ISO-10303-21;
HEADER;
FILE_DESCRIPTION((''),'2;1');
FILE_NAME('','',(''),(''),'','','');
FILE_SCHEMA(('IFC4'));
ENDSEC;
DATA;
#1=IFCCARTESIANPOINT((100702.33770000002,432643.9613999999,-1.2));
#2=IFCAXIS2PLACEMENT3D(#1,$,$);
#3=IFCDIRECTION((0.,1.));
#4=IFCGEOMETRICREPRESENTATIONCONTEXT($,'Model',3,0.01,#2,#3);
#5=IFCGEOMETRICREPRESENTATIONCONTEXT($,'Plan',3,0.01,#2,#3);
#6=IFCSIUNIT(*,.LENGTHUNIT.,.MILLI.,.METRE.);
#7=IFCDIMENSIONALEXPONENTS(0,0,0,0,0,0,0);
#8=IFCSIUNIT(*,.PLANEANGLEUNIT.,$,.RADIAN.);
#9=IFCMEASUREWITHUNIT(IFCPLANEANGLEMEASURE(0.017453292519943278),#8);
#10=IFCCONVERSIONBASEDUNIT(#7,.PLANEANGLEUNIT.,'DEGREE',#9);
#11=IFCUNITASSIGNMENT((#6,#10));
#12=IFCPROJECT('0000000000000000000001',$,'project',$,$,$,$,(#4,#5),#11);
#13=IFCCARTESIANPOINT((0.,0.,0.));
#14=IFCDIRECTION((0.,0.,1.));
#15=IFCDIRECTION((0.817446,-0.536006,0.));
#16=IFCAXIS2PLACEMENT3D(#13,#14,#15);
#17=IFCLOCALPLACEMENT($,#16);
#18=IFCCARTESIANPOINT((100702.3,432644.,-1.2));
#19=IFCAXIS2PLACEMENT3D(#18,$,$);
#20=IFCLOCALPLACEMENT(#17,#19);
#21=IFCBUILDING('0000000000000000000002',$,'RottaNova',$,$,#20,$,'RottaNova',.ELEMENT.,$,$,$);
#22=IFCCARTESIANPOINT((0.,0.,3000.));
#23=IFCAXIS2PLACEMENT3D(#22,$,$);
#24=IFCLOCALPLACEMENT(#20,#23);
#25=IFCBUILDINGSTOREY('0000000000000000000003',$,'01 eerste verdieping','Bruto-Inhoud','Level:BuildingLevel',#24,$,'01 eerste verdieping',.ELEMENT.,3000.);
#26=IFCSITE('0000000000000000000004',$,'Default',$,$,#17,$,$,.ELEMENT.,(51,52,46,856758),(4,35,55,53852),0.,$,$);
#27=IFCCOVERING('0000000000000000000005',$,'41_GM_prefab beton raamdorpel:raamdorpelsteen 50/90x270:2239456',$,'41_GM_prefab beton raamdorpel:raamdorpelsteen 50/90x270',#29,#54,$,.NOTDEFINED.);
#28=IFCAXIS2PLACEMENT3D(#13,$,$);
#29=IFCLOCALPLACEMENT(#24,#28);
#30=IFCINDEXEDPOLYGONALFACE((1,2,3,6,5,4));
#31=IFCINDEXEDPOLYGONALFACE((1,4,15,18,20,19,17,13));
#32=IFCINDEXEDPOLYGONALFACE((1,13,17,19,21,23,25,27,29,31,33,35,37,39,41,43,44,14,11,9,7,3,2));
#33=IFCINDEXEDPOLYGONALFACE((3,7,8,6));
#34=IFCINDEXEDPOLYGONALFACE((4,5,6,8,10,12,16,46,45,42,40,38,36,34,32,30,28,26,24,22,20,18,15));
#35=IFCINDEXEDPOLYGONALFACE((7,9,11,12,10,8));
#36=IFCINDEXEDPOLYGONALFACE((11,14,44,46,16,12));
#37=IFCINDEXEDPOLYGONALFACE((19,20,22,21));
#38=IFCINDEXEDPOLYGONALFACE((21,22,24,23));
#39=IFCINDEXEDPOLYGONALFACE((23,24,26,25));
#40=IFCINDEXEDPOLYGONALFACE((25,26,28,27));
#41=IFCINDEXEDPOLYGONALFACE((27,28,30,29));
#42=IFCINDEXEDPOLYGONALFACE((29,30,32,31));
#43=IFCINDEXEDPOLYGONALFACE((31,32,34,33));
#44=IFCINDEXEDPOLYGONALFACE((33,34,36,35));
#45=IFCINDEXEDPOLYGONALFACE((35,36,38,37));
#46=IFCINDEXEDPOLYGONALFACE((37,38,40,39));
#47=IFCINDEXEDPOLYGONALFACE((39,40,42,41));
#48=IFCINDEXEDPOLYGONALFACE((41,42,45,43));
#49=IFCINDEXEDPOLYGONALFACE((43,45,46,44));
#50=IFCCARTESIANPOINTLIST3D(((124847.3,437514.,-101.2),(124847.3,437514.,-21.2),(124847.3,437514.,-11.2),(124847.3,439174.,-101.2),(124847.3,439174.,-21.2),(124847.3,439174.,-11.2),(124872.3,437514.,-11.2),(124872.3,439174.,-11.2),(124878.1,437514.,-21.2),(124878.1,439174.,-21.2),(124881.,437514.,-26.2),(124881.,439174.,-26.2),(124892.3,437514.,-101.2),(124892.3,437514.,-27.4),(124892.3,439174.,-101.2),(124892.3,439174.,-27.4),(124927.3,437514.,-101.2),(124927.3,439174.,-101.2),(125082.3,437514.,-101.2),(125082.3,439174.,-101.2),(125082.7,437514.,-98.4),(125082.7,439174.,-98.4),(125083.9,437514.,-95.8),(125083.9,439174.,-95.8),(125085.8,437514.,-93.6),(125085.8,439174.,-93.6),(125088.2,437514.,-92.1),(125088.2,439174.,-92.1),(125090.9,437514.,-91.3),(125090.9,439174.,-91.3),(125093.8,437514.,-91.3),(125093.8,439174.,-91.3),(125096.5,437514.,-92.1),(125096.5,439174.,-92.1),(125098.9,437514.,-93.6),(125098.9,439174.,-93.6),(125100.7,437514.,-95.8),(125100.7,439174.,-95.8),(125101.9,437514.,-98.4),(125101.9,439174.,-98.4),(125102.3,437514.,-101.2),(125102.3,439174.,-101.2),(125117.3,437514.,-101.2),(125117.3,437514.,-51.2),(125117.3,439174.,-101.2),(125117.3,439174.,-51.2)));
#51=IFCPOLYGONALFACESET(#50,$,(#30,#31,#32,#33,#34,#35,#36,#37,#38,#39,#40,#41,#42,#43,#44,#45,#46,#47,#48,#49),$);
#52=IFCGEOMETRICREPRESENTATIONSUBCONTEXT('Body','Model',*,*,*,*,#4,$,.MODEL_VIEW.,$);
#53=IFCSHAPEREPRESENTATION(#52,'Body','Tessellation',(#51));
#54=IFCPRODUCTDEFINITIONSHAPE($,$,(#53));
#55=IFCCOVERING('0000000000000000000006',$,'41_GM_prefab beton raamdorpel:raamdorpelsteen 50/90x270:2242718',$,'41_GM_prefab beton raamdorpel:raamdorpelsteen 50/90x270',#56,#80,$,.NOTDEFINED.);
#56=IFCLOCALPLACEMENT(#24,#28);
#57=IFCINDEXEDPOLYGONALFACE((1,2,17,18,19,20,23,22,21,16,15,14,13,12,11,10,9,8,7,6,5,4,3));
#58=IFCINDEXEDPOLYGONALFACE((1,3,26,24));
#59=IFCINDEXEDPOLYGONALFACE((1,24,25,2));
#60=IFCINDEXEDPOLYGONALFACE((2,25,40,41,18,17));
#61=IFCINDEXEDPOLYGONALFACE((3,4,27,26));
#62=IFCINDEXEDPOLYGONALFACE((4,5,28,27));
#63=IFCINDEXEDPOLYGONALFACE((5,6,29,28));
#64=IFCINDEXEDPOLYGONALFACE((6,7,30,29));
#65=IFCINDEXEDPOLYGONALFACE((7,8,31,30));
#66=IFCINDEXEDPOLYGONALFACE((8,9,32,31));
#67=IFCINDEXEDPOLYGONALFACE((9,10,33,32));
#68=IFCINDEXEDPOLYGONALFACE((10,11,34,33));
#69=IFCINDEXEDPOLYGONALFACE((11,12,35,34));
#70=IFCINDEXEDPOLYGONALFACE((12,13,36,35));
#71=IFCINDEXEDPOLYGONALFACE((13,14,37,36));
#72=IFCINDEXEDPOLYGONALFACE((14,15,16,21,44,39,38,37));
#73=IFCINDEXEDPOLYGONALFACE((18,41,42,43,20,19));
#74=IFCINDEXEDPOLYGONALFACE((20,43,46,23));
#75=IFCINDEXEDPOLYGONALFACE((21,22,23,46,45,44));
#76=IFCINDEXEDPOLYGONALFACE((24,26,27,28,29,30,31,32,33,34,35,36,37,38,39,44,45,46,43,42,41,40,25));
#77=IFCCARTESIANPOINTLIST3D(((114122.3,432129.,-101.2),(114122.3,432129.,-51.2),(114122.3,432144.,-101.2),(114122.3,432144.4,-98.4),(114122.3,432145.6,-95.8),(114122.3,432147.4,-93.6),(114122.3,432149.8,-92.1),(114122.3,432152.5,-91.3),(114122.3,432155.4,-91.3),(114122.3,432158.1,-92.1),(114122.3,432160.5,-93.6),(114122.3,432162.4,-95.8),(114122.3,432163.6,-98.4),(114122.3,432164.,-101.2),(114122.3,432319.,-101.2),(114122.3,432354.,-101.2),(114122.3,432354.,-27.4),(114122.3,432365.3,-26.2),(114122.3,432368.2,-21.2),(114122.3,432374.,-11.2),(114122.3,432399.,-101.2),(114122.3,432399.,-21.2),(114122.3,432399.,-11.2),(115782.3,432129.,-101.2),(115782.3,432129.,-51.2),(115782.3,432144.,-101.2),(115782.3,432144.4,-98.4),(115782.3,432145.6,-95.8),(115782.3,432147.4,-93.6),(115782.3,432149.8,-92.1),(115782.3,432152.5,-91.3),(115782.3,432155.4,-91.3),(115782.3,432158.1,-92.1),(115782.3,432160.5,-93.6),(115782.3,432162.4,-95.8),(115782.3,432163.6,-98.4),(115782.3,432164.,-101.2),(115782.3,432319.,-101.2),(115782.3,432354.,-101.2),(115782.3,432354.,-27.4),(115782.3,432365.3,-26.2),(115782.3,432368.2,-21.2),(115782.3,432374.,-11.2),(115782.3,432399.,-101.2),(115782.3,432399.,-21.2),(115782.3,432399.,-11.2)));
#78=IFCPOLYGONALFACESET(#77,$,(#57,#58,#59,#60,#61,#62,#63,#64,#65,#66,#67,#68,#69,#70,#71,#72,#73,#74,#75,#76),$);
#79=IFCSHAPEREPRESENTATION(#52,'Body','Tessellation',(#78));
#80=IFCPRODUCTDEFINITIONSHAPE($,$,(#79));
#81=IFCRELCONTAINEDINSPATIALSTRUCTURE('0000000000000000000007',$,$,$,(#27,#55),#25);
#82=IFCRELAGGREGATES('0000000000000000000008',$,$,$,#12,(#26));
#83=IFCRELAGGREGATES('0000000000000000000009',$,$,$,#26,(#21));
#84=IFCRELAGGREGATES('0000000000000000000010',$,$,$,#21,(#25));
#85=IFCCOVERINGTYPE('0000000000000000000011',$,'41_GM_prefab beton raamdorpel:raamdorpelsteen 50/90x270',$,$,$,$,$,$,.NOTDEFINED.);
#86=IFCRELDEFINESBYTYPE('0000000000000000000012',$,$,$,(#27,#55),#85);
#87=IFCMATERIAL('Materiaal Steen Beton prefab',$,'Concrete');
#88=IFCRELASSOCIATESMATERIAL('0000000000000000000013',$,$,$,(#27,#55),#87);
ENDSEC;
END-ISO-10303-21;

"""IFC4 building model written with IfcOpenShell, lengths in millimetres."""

from ifc_helpers import new_model, entity, si_unit, converted_unit, direction, frame, place, context, subcontext, project, spatial, line, arc, indexed_curve, outline, extrude, material, type_object, element, save


model = new_model("IFC4")

# Units and contexts
model_context = context("Model", 3, precision=0.01, world=frame((100702.33770000002, 432643.9613999999, -1.2)), true_north=direction((0.0, 1.0)))
plan_context = context("Plan", 3, precision=0.01, world=frame((100702.33770000002, 432643.9613999999, -1.2)), true_north=direction((0.0, 1.0)))
body_context = subcontext(model_context, "Body", "Model", "MODEL_VIEW")
ifc_project = project(units=[si_unit("LENGTHUNIT", "METRE", prefix="MILLI"), converted_unit("PLANEANGLEUNIT", "DEGREE", entity("IfcPlaneAngleMeasure", 0.017453292519943278), si_unit("PLANEANGLEUNIT", "RADIAN"), dimensions=[0, 0, 0, 0, 0, 0, 0])], contexts=[model_context, plan_context])

# Site, building, storey
site_placement = place(None, frame((0.0, 0.0, 0.0), z_axis=(0.0, 0.0, 1.0), x_axis=(0.817446, -0.536006, 0.0)))
site = spatial("IfcSite", under=ifc_project, at=site_placement, Name="Default", CompositionType="ELEMENT", RefLatitude=(51, 52, 46, 856758), RefLongitude=(4, 35, 55, 53852), RefElevation=0.0)
building_placement = place(site_placement, frame((100702.3, 432644.0, -1.2)))
building = spatial("IfcBuilding", under=site, at=building_placement, Name="RottaNova", LongName="RottaNova", CompositionType="ELEMENT")
storey_placement = place(building_placement, frame((0.0, 0.0, 3000.0)))
storey = spatial("IfcBuildingStorey", under=building, at=storey_placement, Name="01 eerste verdieping", Description="Bruto-Inhoud", ObjectType="Level:BuildingLevel", LongName="01 eerste verdieping", CompositionType="ELEMENT", Elevation=3000.0)

# Shared definitions
ifc_material_1 = material(Name="Materiaal Steen Beton prefab", Category="Concrete")

# Coverings
covering_type = type_object("IfcCoveringType", Name="41_GM_prefab beton raamdorpel:raamdorpelsteen 50/90x270", PredefinedType="NOTDEFINED")
covering_1_placement = place(storey_placement, frame((100702.3, 432644.0, -1.2)))
element("IfcCovering", 1, at=covering_1_placement, inside=storey, type_object=covering_type, material=ifc_material_1, Name="41_GM_prefab beton raamdorpel:raamdorpelsteen 50/90x270:2239456", ObjectType="41_GM_prefab beton raamdorpel:raamdorpelsteen 50/90x270", PredefinedType="NOTDEFINED", context=body_context, shape_type="SweptSolid", body=[
    extrude(outline(indexed_curve([(-79.1, -40.0), (-91.6, -61.6), (-83.0, -66.6), (-13.7, -106.6), (8.8, -67.6), (26.3, -37.3), (103.8, 96.9), (100.1, 110.6), (113.8, 114.2), (121.3, 127.2), (78.0, 152.2), (-55.1, -30.7), (-61.8, -40.0), (-67.6, -40.0)], segments=[line(1, 2, 3, 4, 5, 6, 7), arc(7, 8, 9), line(9, 10, 11, 12, 13, 14, 1)], self_intersect=False)), frame((24244.2, 4870.0, -58.6), z_axis=(0.0, -1.0, 0.0), x_axis=(0.5, 0.0, -0.866025)), (0.0, 0.0, -1.0), 1660.0),
])
covering_2_placement = place(storey_placement, frame((100702.3, 432644.0, -1.2)))
element("IfcCovering", 2, at=covering_2_placement, inside=storey, type_object=covering_type, material=ifc_material_1, Name="41_GM_prefab beton raamdorpel:raamdorpelsteen 50/90x270:2242718", ObjectType="41_GM_prefab beton raamdorpel:raamdorpelsteen 50/90x270", PredefinedType="NOTDEFINED", context=body_context, shape_type="SweptSolid", body=[
    extrude(outline(indexed_curve([(-79.1, -40.0), (-91.6, -61.6), (-83.0, -66.6), (-13.7, -106.6), (8.8, -67.6), (26.3, -37.3), (103.8, 96.9), (100.1, 110.6), (113.8, 114.2), (121.3, 127.2), (78.0, 152.2), (-55.1, -30.7), (-61.8, -40.0), (-67.6, -40.0)], segments=[line(1, 2, 3, 4, 5, 6, 7), arc(7, 8, 9), line(9, 10, 11, 12, 13, 14, 1)], self_intersect=False)), frame((13420.0, -344.2, -58.6), z_axis=(-1.0, 0.0, 0.0), x_axis=(0.0, -0.5, -0.866025)), (0.0, 0.0, -1.0), 1660.0),
])

save(model, "model.ifc")
